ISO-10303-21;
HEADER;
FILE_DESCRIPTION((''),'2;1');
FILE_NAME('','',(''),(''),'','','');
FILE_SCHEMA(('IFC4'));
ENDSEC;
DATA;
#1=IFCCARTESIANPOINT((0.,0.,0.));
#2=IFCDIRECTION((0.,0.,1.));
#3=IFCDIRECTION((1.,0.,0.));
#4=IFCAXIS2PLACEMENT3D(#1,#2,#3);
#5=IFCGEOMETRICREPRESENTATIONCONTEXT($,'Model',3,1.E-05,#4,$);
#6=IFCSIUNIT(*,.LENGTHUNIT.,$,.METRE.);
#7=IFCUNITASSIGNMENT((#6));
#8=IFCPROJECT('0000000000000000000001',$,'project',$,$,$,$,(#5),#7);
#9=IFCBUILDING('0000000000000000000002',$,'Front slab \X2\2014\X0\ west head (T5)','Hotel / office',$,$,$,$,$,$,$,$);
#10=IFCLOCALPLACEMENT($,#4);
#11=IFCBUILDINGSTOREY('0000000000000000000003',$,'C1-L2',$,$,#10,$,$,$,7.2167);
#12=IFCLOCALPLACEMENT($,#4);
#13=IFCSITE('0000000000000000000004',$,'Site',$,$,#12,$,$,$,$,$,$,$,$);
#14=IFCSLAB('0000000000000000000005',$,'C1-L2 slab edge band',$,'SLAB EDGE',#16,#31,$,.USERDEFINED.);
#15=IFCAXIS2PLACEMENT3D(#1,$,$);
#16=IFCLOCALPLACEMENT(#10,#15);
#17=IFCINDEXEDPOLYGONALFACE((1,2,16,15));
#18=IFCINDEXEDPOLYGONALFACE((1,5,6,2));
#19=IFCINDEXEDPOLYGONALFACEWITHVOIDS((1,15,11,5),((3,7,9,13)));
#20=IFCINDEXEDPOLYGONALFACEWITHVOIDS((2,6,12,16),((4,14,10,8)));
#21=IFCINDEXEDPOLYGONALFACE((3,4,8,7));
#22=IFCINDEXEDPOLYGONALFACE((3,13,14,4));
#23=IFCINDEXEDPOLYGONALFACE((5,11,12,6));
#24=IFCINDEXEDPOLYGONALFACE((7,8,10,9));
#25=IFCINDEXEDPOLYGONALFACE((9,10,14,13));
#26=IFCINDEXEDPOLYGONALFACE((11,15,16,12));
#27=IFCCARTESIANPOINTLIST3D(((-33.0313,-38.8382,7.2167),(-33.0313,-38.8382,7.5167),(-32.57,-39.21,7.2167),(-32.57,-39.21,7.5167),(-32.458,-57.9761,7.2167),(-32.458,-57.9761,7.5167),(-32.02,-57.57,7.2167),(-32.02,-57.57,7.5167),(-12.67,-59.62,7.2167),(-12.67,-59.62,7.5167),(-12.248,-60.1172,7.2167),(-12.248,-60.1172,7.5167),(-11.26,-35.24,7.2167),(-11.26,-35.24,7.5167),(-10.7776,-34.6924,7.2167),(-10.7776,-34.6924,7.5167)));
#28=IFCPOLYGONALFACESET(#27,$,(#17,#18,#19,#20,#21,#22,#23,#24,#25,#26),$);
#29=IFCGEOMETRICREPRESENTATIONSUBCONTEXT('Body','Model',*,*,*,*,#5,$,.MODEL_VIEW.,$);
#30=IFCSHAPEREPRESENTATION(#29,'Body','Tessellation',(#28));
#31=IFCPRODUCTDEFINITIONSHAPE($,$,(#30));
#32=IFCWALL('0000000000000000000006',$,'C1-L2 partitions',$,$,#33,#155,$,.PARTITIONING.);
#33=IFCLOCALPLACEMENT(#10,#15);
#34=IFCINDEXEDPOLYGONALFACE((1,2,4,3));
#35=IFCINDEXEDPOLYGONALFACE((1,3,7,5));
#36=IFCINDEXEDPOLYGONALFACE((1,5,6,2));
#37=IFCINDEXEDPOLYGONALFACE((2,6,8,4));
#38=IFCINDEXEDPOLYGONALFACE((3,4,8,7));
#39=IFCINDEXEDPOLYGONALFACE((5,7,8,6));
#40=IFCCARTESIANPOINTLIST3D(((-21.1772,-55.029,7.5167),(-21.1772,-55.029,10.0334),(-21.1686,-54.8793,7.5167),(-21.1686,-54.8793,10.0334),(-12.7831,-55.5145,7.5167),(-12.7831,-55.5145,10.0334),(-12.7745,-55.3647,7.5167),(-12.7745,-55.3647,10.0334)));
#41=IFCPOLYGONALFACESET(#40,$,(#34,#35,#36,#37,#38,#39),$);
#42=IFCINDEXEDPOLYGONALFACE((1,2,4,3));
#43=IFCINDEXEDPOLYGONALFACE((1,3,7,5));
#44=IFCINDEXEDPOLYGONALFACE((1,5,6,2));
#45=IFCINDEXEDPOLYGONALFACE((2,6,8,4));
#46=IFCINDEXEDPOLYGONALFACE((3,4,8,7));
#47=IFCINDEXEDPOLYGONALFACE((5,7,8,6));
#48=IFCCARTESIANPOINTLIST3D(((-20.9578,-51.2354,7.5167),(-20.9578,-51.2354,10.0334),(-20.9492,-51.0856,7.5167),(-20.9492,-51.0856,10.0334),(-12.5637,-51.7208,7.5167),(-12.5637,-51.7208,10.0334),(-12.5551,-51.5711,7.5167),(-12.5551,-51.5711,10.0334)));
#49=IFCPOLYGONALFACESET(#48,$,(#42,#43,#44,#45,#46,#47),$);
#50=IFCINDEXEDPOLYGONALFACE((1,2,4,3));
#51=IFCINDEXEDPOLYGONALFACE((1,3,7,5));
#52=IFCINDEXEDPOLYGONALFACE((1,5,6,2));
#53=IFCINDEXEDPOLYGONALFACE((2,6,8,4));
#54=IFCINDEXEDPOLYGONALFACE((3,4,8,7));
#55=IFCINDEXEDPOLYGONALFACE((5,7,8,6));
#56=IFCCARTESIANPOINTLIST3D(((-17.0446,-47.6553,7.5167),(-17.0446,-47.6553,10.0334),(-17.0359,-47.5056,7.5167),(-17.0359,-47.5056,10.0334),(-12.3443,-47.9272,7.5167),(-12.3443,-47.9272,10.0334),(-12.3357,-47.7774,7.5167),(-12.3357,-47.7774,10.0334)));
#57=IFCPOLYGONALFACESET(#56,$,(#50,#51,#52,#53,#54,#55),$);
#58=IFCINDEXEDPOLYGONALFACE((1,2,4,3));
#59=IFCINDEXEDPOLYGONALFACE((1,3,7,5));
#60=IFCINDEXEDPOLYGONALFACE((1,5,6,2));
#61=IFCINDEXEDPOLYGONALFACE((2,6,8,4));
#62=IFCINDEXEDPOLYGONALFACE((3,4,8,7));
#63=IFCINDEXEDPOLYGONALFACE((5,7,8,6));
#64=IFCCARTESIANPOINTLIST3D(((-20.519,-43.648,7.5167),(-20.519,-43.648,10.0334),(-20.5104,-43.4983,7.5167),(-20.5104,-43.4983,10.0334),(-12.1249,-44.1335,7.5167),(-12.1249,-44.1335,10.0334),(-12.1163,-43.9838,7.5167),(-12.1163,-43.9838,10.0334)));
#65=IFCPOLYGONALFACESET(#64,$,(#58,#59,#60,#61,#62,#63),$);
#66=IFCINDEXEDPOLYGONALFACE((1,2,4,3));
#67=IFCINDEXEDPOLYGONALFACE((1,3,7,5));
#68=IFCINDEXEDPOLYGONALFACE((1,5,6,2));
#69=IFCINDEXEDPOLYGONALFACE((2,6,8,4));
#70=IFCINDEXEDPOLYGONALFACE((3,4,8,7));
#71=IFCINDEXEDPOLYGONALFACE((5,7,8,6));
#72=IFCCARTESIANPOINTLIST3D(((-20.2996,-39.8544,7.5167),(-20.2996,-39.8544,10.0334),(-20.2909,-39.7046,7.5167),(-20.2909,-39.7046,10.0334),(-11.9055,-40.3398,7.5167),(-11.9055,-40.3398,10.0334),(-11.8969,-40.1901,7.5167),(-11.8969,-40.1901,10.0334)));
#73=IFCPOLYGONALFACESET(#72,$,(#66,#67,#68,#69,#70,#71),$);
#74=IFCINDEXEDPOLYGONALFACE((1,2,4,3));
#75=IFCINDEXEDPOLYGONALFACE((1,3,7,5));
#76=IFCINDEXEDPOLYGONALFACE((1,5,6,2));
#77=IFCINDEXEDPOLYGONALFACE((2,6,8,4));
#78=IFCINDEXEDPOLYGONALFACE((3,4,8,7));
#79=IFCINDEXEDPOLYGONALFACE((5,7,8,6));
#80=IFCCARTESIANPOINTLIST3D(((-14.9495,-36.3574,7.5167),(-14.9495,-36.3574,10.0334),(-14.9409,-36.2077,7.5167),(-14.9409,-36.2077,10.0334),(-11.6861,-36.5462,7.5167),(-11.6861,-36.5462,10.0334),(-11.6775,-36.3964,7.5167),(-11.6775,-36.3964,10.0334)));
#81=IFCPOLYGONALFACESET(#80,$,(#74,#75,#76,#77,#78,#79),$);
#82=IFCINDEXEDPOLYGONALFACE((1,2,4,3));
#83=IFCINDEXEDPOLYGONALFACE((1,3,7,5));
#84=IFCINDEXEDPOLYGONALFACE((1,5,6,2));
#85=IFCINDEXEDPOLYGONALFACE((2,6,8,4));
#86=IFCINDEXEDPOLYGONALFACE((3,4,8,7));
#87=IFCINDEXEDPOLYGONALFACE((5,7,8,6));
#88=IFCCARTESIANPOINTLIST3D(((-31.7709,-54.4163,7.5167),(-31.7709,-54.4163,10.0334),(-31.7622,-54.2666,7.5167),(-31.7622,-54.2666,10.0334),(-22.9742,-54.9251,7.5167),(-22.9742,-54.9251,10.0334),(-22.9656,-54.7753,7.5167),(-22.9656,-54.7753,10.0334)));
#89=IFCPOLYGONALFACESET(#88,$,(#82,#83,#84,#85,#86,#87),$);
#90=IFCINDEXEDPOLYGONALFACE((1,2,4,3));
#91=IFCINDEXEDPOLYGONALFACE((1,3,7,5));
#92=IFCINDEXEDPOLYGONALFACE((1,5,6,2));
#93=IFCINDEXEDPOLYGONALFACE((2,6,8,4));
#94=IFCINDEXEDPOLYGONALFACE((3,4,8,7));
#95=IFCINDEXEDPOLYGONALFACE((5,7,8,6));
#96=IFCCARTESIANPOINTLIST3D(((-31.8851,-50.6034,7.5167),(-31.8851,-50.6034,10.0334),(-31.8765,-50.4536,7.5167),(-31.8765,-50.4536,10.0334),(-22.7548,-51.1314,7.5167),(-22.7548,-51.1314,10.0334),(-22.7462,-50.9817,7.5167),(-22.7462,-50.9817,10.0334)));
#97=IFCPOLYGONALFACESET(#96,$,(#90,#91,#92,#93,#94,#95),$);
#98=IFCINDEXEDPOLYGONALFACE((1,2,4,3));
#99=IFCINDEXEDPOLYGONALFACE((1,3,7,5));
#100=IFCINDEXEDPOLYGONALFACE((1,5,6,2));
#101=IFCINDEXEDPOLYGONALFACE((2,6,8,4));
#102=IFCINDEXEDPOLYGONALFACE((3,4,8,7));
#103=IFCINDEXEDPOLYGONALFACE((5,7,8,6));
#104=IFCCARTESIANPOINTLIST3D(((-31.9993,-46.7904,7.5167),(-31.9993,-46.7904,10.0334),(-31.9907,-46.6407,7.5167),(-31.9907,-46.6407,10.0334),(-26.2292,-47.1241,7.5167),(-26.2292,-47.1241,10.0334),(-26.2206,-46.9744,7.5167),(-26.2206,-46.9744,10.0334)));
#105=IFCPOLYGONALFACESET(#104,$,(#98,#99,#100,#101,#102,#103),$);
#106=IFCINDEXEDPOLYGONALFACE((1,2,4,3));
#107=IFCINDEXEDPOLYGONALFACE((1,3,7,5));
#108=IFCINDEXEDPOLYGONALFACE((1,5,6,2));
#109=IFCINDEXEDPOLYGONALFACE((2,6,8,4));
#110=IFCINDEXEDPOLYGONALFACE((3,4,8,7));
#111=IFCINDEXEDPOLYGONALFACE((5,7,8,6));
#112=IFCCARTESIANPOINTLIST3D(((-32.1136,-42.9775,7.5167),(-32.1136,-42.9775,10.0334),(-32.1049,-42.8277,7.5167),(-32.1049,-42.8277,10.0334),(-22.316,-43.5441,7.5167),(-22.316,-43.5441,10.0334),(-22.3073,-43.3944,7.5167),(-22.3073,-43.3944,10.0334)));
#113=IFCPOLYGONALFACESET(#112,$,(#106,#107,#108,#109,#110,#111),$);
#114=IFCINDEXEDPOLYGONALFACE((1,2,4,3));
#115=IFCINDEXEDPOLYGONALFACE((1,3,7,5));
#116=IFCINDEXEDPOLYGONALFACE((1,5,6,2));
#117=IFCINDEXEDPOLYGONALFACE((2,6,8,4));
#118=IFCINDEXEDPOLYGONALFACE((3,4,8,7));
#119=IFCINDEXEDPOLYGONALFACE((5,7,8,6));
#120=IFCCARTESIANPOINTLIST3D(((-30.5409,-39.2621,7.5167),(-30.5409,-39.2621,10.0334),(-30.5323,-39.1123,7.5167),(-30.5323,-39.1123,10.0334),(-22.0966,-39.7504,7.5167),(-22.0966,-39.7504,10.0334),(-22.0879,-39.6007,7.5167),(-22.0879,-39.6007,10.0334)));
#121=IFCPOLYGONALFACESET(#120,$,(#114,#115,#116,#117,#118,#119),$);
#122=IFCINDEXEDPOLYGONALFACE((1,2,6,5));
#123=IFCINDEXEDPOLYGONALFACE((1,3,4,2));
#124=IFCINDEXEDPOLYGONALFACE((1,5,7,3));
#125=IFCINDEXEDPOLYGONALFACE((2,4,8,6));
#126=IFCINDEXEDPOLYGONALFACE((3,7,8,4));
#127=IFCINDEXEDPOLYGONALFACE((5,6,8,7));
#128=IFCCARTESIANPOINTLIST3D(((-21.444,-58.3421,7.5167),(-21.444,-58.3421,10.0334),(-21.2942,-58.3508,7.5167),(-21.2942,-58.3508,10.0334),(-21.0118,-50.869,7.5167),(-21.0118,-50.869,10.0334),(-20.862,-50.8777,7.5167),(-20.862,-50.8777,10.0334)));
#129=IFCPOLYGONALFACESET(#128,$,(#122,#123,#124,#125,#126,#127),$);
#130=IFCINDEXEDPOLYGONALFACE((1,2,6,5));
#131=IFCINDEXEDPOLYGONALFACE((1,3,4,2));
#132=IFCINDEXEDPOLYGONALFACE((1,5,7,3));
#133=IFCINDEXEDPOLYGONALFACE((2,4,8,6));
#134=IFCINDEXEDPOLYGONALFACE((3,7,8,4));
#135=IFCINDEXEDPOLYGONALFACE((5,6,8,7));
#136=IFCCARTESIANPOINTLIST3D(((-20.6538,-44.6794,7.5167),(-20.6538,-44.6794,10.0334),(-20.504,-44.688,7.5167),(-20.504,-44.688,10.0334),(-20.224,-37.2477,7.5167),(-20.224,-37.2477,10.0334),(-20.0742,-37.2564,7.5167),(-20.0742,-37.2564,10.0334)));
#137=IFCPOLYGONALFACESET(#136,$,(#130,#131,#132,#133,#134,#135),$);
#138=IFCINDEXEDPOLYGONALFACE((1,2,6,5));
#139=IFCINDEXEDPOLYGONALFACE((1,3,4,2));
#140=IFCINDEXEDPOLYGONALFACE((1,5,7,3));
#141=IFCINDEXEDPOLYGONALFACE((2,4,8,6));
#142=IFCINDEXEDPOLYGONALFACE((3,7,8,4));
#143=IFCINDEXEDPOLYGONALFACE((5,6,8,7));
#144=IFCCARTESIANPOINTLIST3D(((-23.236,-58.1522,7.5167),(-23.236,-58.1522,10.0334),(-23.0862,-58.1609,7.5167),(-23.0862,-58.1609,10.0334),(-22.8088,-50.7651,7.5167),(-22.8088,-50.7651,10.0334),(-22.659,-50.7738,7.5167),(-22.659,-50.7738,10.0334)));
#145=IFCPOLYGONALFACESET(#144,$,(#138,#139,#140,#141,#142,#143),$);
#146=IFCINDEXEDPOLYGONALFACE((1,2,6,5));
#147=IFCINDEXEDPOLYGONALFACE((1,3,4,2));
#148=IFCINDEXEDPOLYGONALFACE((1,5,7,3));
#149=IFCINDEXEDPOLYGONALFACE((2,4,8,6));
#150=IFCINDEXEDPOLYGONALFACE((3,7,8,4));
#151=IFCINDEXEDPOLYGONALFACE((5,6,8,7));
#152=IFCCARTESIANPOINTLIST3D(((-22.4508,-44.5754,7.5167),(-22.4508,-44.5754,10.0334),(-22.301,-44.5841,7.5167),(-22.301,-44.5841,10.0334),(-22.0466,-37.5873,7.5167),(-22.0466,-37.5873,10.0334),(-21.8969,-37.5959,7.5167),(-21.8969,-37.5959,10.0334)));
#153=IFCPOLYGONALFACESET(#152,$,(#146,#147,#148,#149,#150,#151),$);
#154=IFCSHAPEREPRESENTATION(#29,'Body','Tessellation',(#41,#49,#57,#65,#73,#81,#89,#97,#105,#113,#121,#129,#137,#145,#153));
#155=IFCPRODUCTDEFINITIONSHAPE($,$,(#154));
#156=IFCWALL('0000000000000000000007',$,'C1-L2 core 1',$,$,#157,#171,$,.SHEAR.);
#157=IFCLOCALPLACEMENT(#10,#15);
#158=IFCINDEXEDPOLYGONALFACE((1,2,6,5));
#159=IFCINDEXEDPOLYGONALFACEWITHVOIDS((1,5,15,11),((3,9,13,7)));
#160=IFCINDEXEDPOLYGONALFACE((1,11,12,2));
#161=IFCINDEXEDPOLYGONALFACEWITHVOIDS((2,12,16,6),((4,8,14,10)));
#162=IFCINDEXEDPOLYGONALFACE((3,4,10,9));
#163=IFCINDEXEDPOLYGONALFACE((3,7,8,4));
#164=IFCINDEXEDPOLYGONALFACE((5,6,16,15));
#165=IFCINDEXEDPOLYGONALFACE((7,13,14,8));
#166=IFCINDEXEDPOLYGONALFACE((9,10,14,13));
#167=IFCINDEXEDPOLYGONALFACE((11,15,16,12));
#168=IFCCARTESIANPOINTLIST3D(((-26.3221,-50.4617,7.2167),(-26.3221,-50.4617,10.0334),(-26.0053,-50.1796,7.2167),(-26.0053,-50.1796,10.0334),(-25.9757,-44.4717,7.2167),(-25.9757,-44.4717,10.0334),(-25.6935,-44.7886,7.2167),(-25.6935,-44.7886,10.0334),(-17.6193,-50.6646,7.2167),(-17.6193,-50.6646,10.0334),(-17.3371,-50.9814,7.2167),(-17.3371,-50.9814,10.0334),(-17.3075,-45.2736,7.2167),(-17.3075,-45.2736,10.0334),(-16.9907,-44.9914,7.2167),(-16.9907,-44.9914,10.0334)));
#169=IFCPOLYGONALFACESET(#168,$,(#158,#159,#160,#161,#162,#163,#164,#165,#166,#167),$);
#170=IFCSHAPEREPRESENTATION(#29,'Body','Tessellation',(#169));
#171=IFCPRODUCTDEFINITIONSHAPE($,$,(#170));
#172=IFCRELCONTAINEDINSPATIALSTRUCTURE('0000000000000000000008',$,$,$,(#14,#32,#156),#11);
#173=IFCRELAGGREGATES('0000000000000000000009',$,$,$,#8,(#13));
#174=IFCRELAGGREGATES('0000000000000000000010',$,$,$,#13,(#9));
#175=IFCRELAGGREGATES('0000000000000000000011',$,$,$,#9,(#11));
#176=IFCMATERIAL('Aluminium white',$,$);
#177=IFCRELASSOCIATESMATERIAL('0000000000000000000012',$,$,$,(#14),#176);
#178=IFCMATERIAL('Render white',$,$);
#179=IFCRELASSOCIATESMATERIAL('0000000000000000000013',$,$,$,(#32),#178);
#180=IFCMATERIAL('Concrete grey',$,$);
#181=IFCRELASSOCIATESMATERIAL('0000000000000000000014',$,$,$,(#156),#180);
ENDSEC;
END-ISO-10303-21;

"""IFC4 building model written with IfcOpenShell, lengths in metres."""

from ifc_helpers import new_model, si_unit, frame, origin_with_axes, place, context, subcontext, project, spatial, polyline, outline, extrude, material, element, save


model = new_model("IFC4")

# Units and contexts
model_context = context("Model", 3, precision=1e-05, world=origin_with_axes())
body_context = subcontext(model_context, "Body", "Model", "MODEL_VIEW")
ifc_project = project(units=[si_unit("LENGTHUNIT", "METRE")], contexts=[model_context])

# Site, building, storey
site_placement = place(None, origin_with_axes())
site = spatial("IfcSite", under=ifc_project, at=site_placement, Name="Site")
building = spatial("IfcBuilding", under=site, Name="Front slab — west head (T5)", Description="Hotel / office")
storey_placement = place(None, origin_with_axes())
storey = spatial("IfcBuildingStorey", under=building, at=storey_placement, Name="C1-L2", Elevation=7.2167)

# Shared definitions
ifc_material_1 = material(Name="Aluminium white")

# Slab
slab_placement = place(storey_placement, origin_with_axes())
element("IfcSlab", 1, at=slab_placement, inside=storey, material=ifc_material_1, Name="C1-L2 slab edge band", ObjectType="SLAB EDGE", PredefinedType="USERDEFINED", context=body_context, shape_type="SweptSolid", body=[
    extrude(outline(polyline([(-33.0313, -38.8382), (-32.458, -57.9761), (-12.248, -60.1172), (-10.7776, -34.6924), (-33.0313, -38.8382)]), holes=[polyline([(-32.57, -39.21), (-32.02, -57.57), (-12.67, -59.62), (-11.26, -35.24), (-32.57, -39.21)])]), frame((0.0, 0.0, 7.2167), z_axis=(0.0, 0.0, 1.0), x_axis=(1.0, 0.0, 0.0)), (0.0, 0.0, 1.0), 0.3),
])

# Walls
ifc_material_2 = material(Name="Render white")
wall_1_placement = place(storey_placement, origin_with_axes())
element("IfcWall", 2, at=wall_1_placement, inside=storey, material=ifc_material_2, Name="C1-L2 partitions", PredefinedType="PARTITIONING", context=body_context, shape_type="SweptSolid", body=[
    extrude(outline(polyline([(-12.7745, -55.3647), (-21.1686, -54.8793), (-21.1772, -55.029), (-12.7831, -55.5145), (-12.7745, -55.3647)])), frame((0.0, 0.0, 7.5167), z_axis=(0.0, 0.0, 1.0), x_axis=(1.0, 0.0, 0.0)), (0.0, 0.0, 1.0), 2.5167),
    extrude(outline(polyline([(-12.5551, -51.5711), (-20.9492, -51.0856), (-20.9578, -51.2354), (-12.5637, -51.7208), (-12.5551, -51.5711)])), frame((0.0, 0.0, 7.5167), z_axis=(0.0, 0.0, 1.0), x_axis=(1.0, 0.0, 0.0)), (0.0, 0.0, 1.0), 2.5167),
    extrude(outline(polyline([(-12.3357, -47.7774), (-17.0359, -47.5056), (-17.0446, -47.6553), (-12.3443, -47.9272), (-12.3357, -47.7774)])), frame((0.0, 0.0, 7.5167), z_axis=(0.0, 0.0, 1.0), x_axis=(1.0, 0.0, 0.0)), (0.0, 0.0, 1.0), 2.5167),
    extrude(outline(polyline([(-12.1163, -43.9838), (-20.5104, -43.4983), (-20.519, -43.648), (-12.1249, -44.1335), (-12.1163, -43.9838)])), frame((0.0, 0.0, 7.5167), z_axis=(0.0, 0.0, 1.0), x_axis=(1.0, 0.0, 0.0)), (0.0, 0.0, 1.0), 2.5167),
    extrude(outline(polyline([(-11.8969, -40.1901), (-20.2909, -39.7046), (-20.2996, -39.8544), (-11.9055, -40.3398), (-11.8969, -40.1901)])), frame((0.0, 0.0, 7.5167), z_axis=(0.0, 0.0, 1.0), x_axis=(1.0, 0.0, 0.0)), (0.0, 0.0, 1.0), 2.5167),
    extrude(outline(polyline([(-11.6775, -36.3964), (-14.9409, -36.2077), (-14.9495, -36.3574), (-11.6861, -36.5462), (-11.6775, -36.3964)])), frame((0.0, 0.0, 7.5167), z_axis=(0.0, 0.0, 1.0), x_axis=(1.0, 0.0, 0.0)), (0.0, 0.0, 1.0), 2.5167),
    extrude(outline(polyline([(-22.9656, -54.7753), (-31.7622, -54.2666), (-31.7709, -54.4163), (-22.9742, -54.9251), (-22.9656, -54.7753)])), frame((0.0, 0.0, 7.5167), z_axis=(0.0, 0.0, 1.0), x_axis=(1.0, 0.0, 0.0)), (0.0, 0.0, 1.0), 2.5167),
    extrude(outline(polyline([(-22.7462, -50.9817), (-31.8765, -50.4536), (-31.8851, -50.6034), (-22.7548, -51.1314), (-22.7462, -50.9817)])), frame((0.0, 0.0, 7.5167), z_axis=(0.0, 0.0, 1.0), x_axis=(1.0, 0.0, 0.0)), (0.0, 0.0, 1.0), 2.5167),
    extrude(outline(polyline([(-26.2206, -46.9744), (-31.9907, -46.6407), (-31.9993, -46.7904), (-26.2292, -47.1241), (-26.2206, -46.9744)])), frame((0.0, 0.0, 7.5167), z_axis=(0.0, 0.0, 1.0), x_axis=(1.0, 0.0, 0.0)), (0.0, 0.0, 1.0), 2.5167),
    extrude(outline(polyline([(-22.3073, -43.3944), (-32.1049, -42.8277), (-32.1136, -42.9775), (-22.316, -43.5441), (-22.3073, -43.3944)])), frame((0.0, 0.0, 7.5167), z_axis=(0.0, 0.0, 1.0), x_axis=(1.0, 0.0, 0.0)), (0.0, 0.0, 1.0), 2.5167),
    extrude(outline(polyline([(-22.0879, -39.6007), (-30.5323, -39.1123), (-30.5409, -39.2621), (-22.0966, -39.7504), (-22.0879, -39.6007)])), frame((0.0, 0.0, 7.5167), z_axis=(0.0, 0.0, 1.0), x_axis=(1.0, 0.0, 0.0)), (0.0, 0.0, 1.0), 2.5167),
    extrude(outline(polyline([(-21.2942, -58.3508), (-20.862, -50.8777), (-21.0118, -50.869), (-21.444, -58.3421), (-21.2942, -58.3508)])), frame((0.0, 0.0, 7.5167), z_axis=(0.0, 0.0, 1.0), x_axis=(1.0, 0.0, 0.0)), (0.0, 0.0, 1.0), 2.5167),
    extrude(outline(polyline([(-20.504, -44.688), (-20.0742, -37.2564), (-20.224, -37.2477), (-20.6538, -44.6794), (-20.504, -44.688)])), frame((0.0, 0.0, 7.5167), z_axis=(0.0, 0.0, 1.0), x_axis=(1.0, 0.0, 0.0)), (0.0, 0.0, 1.0), 2.5167),
    extrude(outline(polyline([(-23.0862, -58.1609), (-22.659, -50.7738), (-22.8088, -50.7651), (-23.236, -58.1522), (-23.0862, -58.1609)])), frame((0.0, 0.0, 7.5167), z_axis=(0.0, 0.0, 1.0), x_axis=(1.0, 0.0, 0.0)), (0.0, 0.0, 1.0), 2.5167),
    extrude(outline(polyline([(-22.301, -44.5841), (-21.8969, -37.5959), (-22.0466, -37.5873), (-22.4508, -44.5754), (-22.301, -44.5841)])), frame((0.0, 0.0, 7.5167), z_axis=(0.0, 0.0, 1.0), x_axis=(1.0, 0.0, 0.0)), (0.0, 0.0, 1.0), 2.5167),
])
ifc_material_3 = material(Name="Concrete grey")
wall_2_placement = place(storey_placement, origin_with_axes())
element("IfcWall", 3, at=wall_2_placement, inside=storey, material=ifc_material_3, Name="C1-L2 core 1", PredefinedType="SHEAR", context=body_context, shape_type="SweptSolid", body=[
    extrude(outline(polyline([(-17.3371, -50.9814), (-16.9907, -44.9914), (-25.9757, -44.4717), (-26.3221, -50.4617), (-17.3371, -50.9814)]), holes=[polyline([(-17.6193, -50.6646), (-17.3075, -45.2736), (-25.6935, -44.7886), (-26.0053, -50.1796), (-17.6193, -50.6646)])]), frame((0.0, 0.0, 7.2167), z_axis=(0.0, 0.0, 1.0), x_axis=(1.0, 0.0, 0.0)), (0.0, 0.0, 1.0), 2.8167),
])

save(model, "model.ifc")
